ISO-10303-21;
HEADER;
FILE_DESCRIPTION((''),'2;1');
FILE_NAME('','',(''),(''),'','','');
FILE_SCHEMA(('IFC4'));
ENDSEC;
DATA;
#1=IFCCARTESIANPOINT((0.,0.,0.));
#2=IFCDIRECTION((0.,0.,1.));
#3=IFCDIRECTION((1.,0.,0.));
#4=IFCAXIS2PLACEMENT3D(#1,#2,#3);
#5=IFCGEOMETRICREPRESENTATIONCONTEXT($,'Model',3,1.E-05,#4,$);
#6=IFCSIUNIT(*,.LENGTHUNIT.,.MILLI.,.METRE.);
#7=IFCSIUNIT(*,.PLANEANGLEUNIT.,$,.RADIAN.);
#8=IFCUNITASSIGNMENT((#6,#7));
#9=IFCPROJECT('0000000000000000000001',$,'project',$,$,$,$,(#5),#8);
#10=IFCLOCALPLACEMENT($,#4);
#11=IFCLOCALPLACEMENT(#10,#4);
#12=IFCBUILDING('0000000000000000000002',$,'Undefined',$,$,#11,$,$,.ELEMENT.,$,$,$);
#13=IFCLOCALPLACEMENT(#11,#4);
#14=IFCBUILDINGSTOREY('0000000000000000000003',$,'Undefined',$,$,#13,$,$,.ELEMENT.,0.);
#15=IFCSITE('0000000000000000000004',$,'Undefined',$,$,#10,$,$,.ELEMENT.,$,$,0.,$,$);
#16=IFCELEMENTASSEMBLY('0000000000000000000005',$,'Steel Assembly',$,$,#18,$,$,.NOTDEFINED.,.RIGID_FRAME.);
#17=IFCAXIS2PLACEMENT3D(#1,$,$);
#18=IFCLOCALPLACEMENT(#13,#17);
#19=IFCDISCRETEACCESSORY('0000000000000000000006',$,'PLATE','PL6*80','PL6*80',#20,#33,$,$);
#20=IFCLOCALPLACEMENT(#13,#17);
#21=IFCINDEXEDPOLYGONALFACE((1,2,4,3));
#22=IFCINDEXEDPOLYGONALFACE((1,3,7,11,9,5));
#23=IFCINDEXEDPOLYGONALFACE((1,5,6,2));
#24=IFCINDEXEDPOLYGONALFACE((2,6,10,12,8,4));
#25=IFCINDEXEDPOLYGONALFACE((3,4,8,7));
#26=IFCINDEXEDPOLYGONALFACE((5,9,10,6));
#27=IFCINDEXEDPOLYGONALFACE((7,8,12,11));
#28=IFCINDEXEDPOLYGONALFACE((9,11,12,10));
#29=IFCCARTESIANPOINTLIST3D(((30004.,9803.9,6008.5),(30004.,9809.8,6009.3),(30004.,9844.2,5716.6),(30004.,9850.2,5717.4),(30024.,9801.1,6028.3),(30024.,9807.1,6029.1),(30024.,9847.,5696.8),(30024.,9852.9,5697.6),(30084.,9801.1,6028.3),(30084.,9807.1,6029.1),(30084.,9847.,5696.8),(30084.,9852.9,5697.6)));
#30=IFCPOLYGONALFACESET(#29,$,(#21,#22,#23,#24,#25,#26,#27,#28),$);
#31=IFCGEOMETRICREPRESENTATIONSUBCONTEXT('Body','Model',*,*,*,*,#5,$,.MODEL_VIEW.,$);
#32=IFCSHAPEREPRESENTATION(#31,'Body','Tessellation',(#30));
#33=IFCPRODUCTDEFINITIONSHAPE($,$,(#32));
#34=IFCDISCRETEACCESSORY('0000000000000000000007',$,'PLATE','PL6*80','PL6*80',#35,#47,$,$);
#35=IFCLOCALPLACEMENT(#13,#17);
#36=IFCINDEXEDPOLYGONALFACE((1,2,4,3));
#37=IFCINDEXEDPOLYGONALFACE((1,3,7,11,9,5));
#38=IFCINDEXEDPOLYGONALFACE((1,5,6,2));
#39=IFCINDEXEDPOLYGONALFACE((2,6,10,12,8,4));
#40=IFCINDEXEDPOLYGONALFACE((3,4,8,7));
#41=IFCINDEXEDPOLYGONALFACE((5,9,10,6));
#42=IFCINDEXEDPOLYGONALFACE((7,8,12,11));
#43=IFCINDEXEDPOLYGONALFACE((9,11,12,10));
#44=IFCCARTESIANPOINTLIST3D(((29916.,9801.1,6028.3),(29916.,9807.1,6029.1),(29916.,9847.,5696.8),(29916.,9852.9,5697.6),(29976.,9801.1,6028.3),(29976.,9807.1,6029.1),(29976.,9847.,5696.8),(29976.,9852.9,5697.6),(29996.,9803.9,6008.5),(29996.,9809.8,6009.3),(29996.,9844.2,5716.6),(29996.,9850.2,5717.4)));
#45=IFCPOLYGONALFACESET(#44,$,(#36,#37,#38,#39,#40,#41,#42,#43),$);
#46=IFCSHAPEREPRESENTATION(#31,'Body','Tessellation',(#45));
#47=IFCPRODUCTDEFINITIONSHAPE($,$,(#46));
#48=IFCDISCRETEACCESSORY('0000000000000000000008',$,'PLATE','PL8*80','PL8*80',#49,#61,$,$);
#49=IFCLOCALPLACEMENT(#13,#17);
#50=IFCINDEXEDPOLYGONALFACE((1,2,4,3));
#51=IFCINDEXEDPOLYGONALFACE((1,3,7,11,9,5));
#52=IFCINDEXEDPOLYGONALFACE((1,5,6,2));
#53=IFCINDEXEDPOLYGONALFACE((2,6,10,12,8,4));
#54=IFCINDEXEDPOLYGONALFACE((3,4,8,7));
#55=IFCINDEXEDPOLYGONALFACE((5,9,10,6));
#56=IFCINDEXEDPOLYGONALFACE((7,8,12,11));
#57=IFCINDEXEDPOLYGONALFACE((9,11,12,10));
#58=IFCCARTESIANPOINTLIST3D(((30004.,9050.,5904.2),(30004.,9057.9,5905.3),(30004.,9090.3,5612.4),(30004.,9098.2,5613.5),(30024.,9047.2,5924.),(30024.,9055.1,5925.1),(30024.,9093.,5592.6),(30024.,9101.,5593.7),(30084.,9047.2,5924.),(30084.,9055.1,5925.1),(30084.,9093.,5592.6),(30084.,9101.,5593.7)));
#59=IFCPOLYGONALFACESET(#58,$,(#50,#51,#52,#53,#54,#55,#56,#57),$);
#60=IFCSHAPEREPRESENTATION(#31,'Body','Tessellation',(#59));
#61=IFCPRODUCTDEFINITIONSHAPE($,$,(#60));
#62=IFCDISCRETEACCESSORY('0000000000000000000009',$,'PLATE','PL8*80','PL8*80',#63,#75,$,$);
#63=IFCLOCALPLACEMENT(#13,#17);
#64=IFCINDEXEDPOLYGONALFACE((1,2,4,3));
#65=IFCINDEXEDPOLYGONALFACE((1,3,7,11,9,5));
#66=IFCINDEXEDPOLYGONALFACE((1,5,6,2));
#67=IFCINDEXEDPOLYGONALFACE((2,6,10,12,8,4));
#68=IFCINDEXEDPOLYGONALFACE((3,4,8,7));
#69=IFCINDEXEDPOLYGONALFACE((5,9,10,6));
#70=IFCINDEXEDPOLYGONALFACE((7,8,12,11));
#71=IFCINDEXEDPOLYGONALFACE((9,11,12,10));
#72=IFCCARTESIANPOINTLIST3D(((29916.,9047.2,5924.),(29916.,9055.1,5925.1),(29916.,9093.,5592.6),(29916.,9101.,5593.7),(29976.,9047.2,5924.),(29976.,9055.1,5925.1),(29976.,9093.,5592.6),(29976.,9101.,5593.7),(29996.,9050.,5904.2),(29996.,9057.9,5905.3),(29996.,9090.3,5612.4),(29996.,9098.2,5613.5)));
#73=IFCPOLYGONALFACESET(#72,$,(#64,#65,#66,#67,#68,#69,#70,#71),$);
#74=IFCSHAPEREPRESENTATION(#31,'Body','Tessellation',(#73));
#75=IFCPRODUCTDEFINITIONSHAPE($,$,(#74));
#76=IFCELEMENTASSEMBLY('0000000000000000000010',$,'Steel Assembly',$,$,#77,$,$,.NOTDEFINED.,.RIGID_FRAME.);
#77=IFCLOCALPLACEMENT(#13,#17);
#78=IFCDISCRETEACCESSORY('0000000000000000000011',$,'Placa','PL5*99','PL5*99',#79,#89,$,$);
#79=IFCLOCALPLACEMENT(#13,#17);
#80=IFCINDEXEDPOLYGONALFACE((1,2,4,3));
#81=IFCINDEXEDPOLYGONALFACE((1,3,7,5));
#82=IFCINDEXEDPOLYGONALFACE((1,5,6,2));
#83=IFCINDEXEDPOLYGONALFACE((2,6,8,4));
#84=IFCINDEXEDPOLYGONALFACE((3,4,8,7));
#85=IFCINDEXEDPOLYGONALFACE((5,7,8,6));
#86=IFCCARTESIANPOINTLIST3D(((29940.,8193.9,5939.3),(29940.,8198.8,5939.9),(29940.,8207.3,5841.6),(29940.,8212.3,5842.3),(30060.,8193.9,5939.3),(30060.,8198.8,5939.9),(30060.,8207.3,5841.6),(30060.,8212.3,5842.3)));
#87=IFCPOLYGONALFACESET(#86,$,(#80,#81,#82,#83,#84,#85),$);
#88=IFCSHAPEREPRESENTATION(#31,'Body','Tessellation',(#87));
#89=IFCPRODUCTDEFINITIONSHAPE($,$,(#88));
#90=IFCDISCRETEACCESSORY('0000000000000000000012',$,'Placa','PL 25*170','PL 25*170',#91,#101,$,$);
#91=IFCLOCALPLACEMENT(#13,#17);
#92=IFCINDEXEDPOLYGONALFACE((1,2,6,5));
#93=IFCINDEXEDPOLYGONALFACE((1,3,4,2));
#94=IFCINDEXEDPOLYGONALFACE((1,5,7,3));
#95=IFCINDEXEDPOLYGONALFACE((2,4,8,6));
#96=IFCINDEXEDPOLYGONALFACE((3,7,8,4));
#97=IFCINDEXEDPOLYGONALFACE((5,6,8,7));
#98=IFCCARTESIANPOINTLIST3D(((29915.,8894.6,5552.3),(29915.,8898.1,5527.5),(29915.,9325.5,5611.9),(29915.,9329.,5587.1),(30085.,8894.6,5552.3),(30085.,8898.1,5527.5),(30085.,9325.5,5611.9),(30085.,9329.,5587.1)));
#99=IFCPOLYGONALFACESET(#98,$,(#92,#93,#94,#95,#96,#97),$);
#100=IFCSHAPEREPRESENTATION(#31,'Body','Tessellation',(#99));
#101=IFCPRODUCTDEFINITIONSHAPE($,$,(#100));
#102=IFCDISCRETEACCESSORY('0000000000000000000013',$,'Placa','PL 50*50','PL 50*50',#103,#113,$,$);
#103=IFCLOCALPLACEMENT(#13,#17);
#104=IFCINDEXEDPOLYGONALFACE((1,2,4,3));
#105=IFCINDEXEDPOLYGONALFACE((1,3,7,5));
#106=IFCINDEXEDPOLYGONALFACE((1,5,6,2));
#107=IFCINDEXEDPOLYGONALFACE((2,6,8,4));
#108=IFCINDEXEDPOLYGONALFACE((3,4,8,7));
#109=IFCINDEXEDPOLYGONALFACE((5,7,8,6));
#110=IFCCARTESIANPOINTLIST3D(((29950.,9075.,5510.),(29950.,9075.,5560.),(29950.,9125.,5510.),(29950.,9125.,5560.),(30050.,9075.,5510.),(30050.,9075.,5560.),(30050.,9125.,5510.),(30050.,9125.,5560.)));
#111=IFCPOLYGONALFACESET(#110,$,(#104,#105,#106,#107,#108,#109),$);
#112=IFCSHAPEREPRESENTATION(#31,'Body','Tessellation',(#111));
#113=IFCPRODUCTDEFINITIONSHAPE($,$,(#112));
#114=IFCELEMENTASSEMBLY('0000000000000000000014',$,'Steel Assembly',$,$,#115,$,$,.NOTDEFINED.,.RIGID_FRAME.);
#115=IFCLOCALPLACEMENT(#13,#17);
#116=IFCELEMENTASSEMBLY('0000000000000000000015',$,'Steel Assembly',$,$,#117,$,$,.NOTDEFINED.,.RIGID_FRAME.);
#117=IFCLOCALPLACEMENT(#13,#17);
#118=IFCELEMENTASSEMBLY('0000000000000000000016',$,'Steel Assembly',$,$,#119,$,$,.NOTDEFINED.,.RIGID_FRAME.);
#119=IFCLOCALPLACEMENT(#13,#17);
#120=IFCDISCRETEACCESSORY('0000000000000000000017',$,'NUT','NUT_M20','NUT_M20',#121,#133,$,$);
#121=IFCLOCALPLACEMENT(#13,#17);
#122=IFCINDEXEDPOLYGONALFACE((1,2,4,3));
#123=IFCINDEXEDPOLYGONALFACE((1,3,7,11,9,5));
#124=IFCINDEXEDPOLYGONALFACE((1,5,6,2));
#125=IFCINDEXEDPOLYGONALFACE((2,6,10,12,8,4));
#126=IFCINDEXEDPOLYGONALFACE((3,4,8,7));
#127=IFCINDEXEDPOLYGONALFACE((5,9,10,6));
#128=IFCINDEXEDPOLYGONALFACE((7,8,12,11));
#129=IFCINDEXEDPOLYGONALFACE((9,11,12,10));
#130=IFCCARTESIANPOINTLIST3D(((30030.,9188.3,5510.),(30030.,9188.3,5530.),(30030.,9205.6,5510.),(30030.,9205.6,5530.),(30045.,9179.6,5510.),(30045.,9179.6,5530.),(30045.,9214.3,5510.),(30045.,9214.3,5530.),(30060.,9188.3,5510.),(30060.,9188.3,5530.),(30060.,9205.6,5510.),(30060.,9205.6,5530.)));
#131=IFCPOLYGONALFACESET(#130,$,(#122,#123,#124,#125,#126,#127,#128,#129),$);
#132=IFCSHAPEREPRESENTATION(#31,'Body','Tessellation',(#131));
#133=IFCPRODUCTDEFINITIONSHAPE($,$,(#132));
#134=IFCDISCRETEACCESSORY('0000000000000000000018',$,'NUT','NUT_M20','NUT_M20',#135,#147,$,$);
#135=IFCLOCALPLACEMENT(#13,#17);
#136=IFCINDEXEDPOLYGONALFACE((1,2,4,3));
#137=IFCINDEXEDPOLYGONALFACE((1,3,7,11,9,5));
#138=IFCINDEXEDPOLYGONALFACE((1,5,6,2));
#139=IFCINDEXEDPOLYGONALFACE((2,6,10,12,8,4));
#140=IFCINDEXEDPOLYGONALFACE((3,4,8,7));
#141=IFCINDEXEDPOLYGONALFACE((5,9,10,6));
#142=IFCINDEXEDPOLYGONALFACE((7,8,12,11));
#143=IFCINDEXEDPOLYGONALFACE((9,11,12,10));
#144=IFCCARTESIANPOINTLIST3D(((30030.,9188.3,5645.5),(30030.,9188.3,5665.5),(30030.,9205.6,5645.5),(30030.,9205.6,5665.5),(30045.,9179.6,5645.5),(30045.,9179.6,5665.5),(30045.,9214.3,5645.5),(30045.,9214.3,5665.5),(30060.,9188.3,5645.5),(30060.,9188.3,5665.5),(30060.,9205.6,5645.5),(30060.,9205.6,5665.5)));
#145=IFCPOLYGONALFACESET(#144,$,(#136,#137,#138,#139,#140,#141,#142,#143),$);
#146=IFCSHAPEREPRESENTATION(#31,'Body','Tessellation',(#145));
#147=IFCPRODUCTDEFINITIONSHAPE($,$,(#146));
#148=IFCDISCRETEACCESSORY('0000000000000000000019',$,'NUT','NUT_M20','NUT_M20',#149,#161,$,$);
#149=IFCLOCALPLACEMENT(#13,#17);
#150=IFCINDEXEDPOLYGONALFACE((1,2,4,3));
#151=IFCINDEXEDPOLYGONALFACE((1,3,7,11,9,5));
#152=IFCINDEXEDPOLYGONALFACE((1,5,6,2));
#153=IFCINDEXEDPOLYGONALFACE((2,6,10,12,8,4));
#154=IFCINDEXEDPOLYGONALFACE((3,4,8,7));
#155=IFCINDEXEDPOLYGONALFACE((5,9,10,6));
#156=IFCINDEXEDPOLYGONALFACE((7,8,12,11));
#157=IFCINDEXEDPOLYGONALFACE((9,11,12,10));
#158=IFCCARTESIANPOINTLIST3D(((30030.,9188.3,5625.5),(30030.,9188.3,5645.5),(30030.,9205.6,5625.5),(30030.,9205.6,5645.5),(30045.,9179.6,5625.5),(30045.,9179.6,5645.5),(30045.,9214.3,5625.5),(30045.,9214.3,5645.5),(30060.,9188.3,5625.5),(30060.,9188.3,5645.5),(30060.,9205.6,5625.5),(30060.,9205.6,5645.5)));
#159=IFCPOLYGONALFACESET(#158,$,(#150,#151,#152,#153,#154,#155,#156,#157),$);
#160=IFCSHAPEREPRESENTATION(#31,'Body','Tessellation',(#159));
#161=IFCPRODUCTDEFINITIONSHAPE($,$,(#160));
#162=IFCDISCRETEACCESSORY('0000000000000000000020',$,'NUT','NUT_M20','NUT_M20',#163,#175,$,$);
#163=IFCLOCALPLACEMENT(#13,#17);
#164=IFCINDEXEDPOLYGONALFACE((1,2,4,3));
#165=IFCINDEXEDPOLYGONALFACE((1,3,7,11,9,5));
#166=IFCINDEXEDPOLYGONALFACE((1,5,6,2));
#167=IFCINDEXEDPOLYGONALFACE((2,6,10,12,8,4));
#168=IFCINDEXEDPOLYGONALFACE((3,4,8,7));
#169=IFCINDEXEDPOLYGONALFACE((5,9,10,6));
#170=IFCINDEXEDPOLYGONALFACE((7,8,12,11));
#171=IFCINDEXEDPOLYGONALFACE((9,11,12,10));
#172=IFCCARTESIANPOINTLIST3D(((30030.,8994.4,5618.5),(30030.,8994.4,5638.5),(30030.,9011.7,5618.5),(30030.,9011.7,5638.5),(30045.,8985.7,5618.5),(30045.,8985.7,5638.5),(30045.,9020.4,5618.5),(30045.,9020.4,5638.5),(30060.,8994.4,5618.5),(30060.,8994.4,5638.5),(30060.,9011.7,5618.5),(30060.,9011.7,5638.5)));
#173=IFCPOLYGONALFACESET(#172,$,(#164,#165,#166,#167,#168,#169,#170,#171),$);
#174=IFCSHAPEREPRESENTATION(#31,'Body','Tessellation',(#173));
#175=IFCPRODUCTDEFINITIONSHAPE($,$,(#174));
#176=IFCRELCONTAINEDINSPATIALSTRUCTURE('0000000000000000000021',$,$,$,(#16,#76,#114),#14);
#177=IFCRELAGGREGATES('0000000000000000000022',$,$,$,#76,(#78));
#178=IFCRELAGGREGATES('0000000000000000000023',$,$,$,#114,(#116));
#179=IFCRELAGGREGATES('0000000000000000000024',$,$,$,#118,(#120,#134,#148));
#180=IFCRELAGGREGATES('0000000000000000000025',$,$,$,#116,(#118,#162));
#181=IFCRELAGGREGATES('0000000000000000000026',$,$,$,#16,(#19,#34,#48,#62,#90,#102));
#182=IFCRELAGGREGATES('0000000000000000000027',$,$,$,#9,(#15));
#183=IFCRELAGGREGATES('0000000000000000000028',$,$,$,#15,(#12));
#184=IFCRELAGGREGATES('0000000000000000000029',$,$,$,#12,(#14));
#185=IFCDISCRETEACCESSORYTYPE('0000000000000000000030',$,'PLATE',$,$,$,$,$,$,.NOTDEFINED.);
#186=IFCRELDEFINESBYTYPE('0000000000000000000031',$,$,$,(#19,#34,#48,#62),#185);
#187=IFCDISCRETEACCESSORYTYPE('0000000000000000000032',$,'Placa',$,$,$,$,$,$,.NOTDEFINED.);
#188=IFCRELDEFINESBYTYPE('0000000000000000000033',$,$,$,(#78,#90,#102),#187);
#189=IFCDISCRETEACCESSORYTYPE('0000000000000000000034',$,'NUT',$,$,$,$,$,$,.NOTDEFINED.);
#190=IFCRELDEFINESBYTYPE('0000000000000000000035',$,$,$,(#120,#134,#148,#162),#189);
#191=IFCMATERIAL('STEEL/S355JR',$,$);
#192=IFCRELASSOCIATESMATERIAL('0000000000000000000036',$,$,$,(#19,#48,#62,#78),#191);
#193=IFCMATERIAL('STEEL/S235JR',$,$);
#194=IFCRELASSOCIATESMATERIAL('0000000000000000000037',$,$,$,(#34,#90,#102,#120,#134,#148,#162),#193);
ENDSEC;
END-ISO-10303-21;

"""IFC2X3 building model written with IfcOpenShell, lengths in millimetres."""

from ifc_helpers import new_model, si_unit, frame, origin_with_axes, place, context, subcontext, project, spatial, polyline, outline, extrude, material, type_object, element, aggregate, save


model = new_model("IFC2X3")

# Units and contexts
model_context = context("Model", 3, precision=1e-05, world=origin_with_axes())
body_context = subcontext(model_context, "Body", "Model", "MODEL_VIEW")
ifc_project = project(units=[si_unit("LENGTHUNIT", "METRE", prefix="MILLI"), si_unit("PLANEANGLEUNIT", "RADIAN")], contexts=[model_context])

# Site, building, storey
site_placement = place(None, origin_with_axes())
site = spatial("IfcSite", under=ifc_project, at=site_placement, Name="Undefined", CompositionType="ELEMENT", RefElevation=0.0)
building_placement = place(site_placement, origin_with_axes())
building = spatial("IfcBuilding", under=site, at=building_placement, Name="Undefined", CompositionType="ELEMENT")
storey_placement = place(building_placement, origin_with_axes())
storey = spatial("IfcBuildingStorey", under=building, at=storey_placement, Name="Undefined", CompositionType="ELEMENT", Elevation=0.0)

# Element assembly, discrete accessories
assembly_1_placement = place(storey_placement, origin_with_axes())
assembly_1 = element("IfcElementAssembly", 1, at=assembly_1_placement, inside=storey, Name="Steel Assembly", AssemblyPlace="NOTDEFINED", PredefinedType="RIGID_FRAME")
ifc_material_1 = material(Name="STEEL/S355JR")
discrete_accessory_type_1 = type_object("IfcDiscreteAccessoryType", Name="PLATE")
discrete_accessory_1_placement = place(assembly_1_placement, frame((30084.0, 9850.0, 5697.2), z_axis=(0.0, 0.990574, 0.13698), x_axis=(-1.0, 0.0, 0.0)))
discrete_accessory_1 = element("IfcDiscreteAccessory", 2, at=discrete_accessory_1_placement, type_object=discrete_accessory_type_1, material=ifc_material_1, Name="PLATE", Description="PL6*80", ObjectType="PL6*80", context=body_context, shape_type="SweptSolid", body=[
    extrude(outline(polyline([(0.0, 0.0), (60.0, 0.0), (80.0, 20.0), (80.0, 314.6), (60.0, 334.6), (0.0, 334.6), (0.0, 0.0)])), frame((0.0, 0.0, -3.0), z_axis=(0.0, 0.0, 1.0), x_axis=(1.0, 0.0, 0.0)), (0.0, 0.0, 1.0), 6.0),
])
ifc_material_2 = material(Name="STEEL/S235JR")
discrete_accessory_2_placement = place(assembly_1_placement, frame((29996.0, 9850.0, 5697.2), z_axis=(0.0, 0.990574, 0.13698), x_axis=(-1.0, 0.0, 0.0)))
discrete_accessory_2 = element("IfcDiscreteAccessory", 3, at=discrete_accessory_2_placement, type_object=discrete_accessory_type_1, material=ifc_material_2, Name="PLATE", Description="PL6*80", ObjectType="PL6*80", context=body_context, shape_type="SweptSolid", body=[
    extrude(outline(polyline([(0.0, 20.0), (20.0, 0.0), (80.0, 0.0), (80.0, 334.6), (20.0, 334.6), (0.0, 314.6), (0.0, 20.0)])), frame((0.0, 0.0, -3.0), z_axis=(0.0, 0.0, 1.0), x_axis=(1.0, 0.0, 0.0)), (0.0, 0.0, 1.0), 6.0),
])
discrete_accessory_3_placement = place(assembly_1_placement, frame((30084.0, 9097.0, 5593.1), z_axis=(0.0, 0.990574, 0.13698), x_axis=(-1.0, 0.0, 0.0)))
discrete_accessory_3 = element("IfcDiscreteAccessory", 4, at=discrete_accessory_3_placement, type_object=discrete_accessory_type_1, material=ifc_material_1, Name="PLATE", Description="PL8*80", ObjectType="PL8*80", context=body_context, shape_type="SweptSolid", body=[
    extrude(outline(polyline([(0.0, 0.0), (60.0, 0.0), (80.0, 20.0), (80.0, 314.6), (60.0, 334.6), (0.0, 334.6), (0.0, 0.0)])), frame((0.0, 0.0, -4.0), z_axis=(0.0, 0.0, 1.0), x_axis=(1.0, 0.0, 0.0)), (0.0, 0.0, 1.0), 8.0),
])
discrete_accessory_4_placement = place(assembly_1_placement, frame((29996.0, 9097.0, 5593.1), z_axis=(0.0, 0.990574, 0.13698), x_axis=(-1.0, 0.0, 0.0)))
discrete_accessory_4 = element("IfcDiscreteAccessory", 5, at=discrete_accessory_4_placement, type_object=discrete_accessory_type_1, material=ifc_material_1, Name="PLATE", Description="PL8*80", ObjectType="PL8*80", context=body_context, shape_type="SweptSolid", body=[
    extrude(outline(polyline([(0.0, 20.0), (20.0, 0.0), (80.0, 0.0), (80.0, 334.6), (20.0, 334.6), (0.0, 314.6), (0.0, 20.0)])), frame((0.0, 0.0, -4.0), z_axis=(0.0, 0.0, 1.0), x_axis=(1.0, 0.0, 0.0)), (0.0, 0.0, 1.0), 8.0),
])

# Element assembly, discrete accessory
assembly_2_placement = place(storey_placement, origin_with_axes())
assembly_2 = element("IfcElementAssembly", 6, at=assembly_2_placement, inside=storey, Name="Steel Assembly", AssemblyPlace="NOTDEFINED", PredefinedType="RIGID_FRAME")
discrete_accessory_type_2 = type_object("IfcDiscreteAccessoryType", Name="Placa")
discrete_accessory_5_placement = place(assembly_2_placement, frame((29940.0, 8209.8, 5841.9), z_axis=(0.0, 0.990592, 0.136849), x_axis=(0.0, -0.136849, 0.990592)))
discrete_accessory_5 = element("IfcDiscreteAccessory", 7, at=discrete_accessory_5_placement, type_object=discrete_accessory_type_2, material=ifc_material_1, Name="Placa", Description="PL5*99", ObjectType="PL5*99", context=body_context, shape_type="SweptSolid", body=[
    extrude(outline(polyline([(0.0, 0.0), (98.6, 0.0), (98.6, 120.0), (0.0, 120.0), (0.0, 0.0)])), frame((0.0, 0.0, -2.5), z_axis=(0.0, 0.0, 1.0), x_axis=(1.0, 0.0, 0.0)), (0.0, 0.0, 1.0), 5.0),
])
aggregate(assembly_2, [discrete_accessory_5])

# Discrete accessories
discrete_accessory_6_placement = place(assembly_1_placement, frame((30085.0, 8896.3, 5539.9), z_axis=(0.0, -0.13698, 0.990574), x_axis=(0.0, 0.990574, 0.13698)))
discrete_accessory_6 = element("IfcDiscreteAccessory", 8, at=discrete_accessory_6_placement, type_object=discrete_accessory_type_2, material=ifc_material_2, Name="Placa", Description="PL 25*170", ObjectType="PL 25*170", context=body_context, shape_type="SweptSolid", body=[
    extrude(outline(polyline([(0.0, 0.0), (435.0, 0.0), (435.0, 170.0), (0.0, 170.0), (0.0, 0.0)])), frame((0.0, 0.0, -12.5), z_axis=(0.0, 0.0, 1.0), x_axis=(1.0, 0.0, 0.0)), (0.0, 0.0, 1.0), 25.0),
])
discrete_accessory_7_placement = place(assembly_1_placement, frame((29950.0, 9075.0, 5535.0), z_axis=(0.0, 0.0, 1.0), x_axis=(1.0, 0.0, 0.0)))
discrete_accessory_7 = element("IfcDiscreteAccessory", 9, at=discrete_accessory_7_placement, type_object=discrete_accessory_type_2, material=ifc_material_2, Name="Placa", Description="PL 50*50", ObjectType="PL 50*50", context=body_context, shape_type="SweptSolid", body=[
    extrude(outline(polyline([(0.0, 0.0), (100.0, 0.0), (100.0, 50.0), (0.0, 50.0), (0.0, 0.0)])), frame((0.0, 0.0, -25.0), z_axis=(0.0, 0.0, 1.0), x_axis=(1.0, 0.0, 0.0)), (0.0, 0.0, 1.0), 50.0),
])

# Element assemblies, discrete accessories
assembly_3_placement = place(storey_placement, origin_with_axes())
assembly_3 = element("IfcElementAssembly", 10, at=assembly_3_placement, inside=storey, Name="Steel Assembly", AssemblyPlace="NOTDEFINED", PredefinedType="RIGID_FRAME")
assembly_4_placement = place(assembly_3_placement, origin_with_axes())
assembly_4 = element("IfcElementAssembly", 11, at=assembly_4_placement, Name="Steel Assembly", AssemblyPlace="NOTDEFINED", PredefinedType="RIGID_FRAME")
aggregate(assembly_3, [assembly_4])
assembly_5_placement = place(assembly_4_placement, origin_with_axes())
assembly_5 = element("IfcElementAssembly", 12, at=assembly_5_placement, Name="Steel Assembly", AssemblyPlace="NOTDEFINED", PredefinedType="RIGID_FRAME")
discrete_accessory_type_3 = type_object("IfcDiscreteAccessoryType", Name="NUT")
discrete_accessory_8_placement = place(assembly_5_placement, frame((30045.0, 9197.0, 5530.0), z_axis=(-1.0, 0.0, 0.0), x_axis=(0.0, 0.0, -1.0)))
discrete_accessory_8 = element("IfcDiscreteAccessory", 13, at=discrete_accessory_8_placement, type_object=discrete_accessory_type_3, material=ifc_material_2, Name="NUT", Description="NUT_M20", ObjectType="NUT_M20", context=body_context, shape_type="SweptSolid", body=[
    extrude(outline(polyline([(8.7, 15.0), (17.3, 0.0), (8.7, -15.0), (-8.7, -15.0), (-17.3, 0.0), (-8.7, 15.0), (8.7, 15.0)])), frame((20.0, 0.0, 0.0), z_axis=(-1.0, 0.0, 0.0), x_axis=(0.0, -1.0, 0.0)), (0.0, 0.0, 1.0), 20.0),
])
discrete_accessory_9_placement = place(assembly_5_placement, frame((30045.0, 9197.0, 5665.5), z_axis=(-1.0, 0.0, 0.0), x_axis=(0.0, 0.0, -1.0)))
discrete_accessory_9 = element("IfcDiscreteAccessory", 14, at=discrete_accessory_9_placement, type_object=discrete_accessory_type_3, material=ifc_material_2, Name="NUT", Description="NUT_M20", ObjectType="NUT_M20", context=body_context, shape_type="SweptSolid", body=[
    extrude(outline(polyline([(8.7, 15.0), (17.3, 0.0), (8.7, -15.0), (-8.7, -15.0), (-17.3, 0.0), (-8.7, 15.0), (8.7, 15.0)])), frame((20.0, 0.0, 0.0), z_axis=(-1.0, 0.0, 0.0), x_axis=(0.0, -1.0, 0.0)), (0.0, 0.0, 1.0), 20.0),
])
discrete_accessory_10_placement = place(assembly_5_placement, frame((30045.0, 9197.0, 5645.5), z_axis=(-1.0, 0.0, 0.0), x_axis=(0.0, 0.0, -1.0)))
discrete_accessory_10 = element("IfcDiscreteAccessory", 15, at=discrete_accessory_10_placement, type_object=discrete_accessory_type_3, material=ifc_material_2, Name="NUT", Description="NUT_M20", ObjectType="NUT_M20", context=body_context, shape_type="SweptSolid", body=[
    extrude(outline(polyline([(8.7, 15.0), (17.3, 0.0), (8.7, -15.0), (-8.7, -15.0), (-17.3, 0.0), (-8.7, 15.0), (8.7, 15.0)])), frame((20.0, 0.0, 0.0), z_axis=(-1.0, 0.0, 0.0), x_axis=(0.0, -1.0, 0.0)), (0.0, 0.0, 1.0), 20.0),
])
discrete_accessory_11_placement = place(assembly_4_placement, frame((30045.0, 9003.0, 5638.5), z_axis=(-1.0, 0.0, 0.0), x_axis=(0.0, 0.0, -1.0)))
discrete_accessory_11 = element("IfcDiscreteAccessory", 16, at=discrete_accessory_11_placement, type_object=discrete_accessory_type_3, material=ifc_material_2, Name="NUT", Description="NUT_M20", ObjectType="NUT_M20", context=body_context, shape_type="SweptSolid", body=[
    extrude(outline(polyline([(8.7, 15.0), (17.3, 0.0), (8.7, -15.0), (-8.7, -15.0), (-17.3, 0.0), (-8.7, 15.0), (8.7, 15.0)])), frame((20.0, 0.0, 0.0), z_axis=(-1.0, 0.0, 0.0), x_axis=(0.0, -1.0, 0.0)), (0.0, 0.0, 1.0), 20.0),
])

aggregate(assembly_5, [discrete_accessory_8, discrete_accessory_9, discrete_accessory_10])
aggregate(assembly_4, [assembly_5, discrete_accessory_11])

aggregate(assembly_1, [discrete_accessory_1, discrete_accessory_2, discrete_accessory_3, discrete_accessory_4, discrete_accessory_6, discrete_accessory_7])

save(model, "model.ifc")
